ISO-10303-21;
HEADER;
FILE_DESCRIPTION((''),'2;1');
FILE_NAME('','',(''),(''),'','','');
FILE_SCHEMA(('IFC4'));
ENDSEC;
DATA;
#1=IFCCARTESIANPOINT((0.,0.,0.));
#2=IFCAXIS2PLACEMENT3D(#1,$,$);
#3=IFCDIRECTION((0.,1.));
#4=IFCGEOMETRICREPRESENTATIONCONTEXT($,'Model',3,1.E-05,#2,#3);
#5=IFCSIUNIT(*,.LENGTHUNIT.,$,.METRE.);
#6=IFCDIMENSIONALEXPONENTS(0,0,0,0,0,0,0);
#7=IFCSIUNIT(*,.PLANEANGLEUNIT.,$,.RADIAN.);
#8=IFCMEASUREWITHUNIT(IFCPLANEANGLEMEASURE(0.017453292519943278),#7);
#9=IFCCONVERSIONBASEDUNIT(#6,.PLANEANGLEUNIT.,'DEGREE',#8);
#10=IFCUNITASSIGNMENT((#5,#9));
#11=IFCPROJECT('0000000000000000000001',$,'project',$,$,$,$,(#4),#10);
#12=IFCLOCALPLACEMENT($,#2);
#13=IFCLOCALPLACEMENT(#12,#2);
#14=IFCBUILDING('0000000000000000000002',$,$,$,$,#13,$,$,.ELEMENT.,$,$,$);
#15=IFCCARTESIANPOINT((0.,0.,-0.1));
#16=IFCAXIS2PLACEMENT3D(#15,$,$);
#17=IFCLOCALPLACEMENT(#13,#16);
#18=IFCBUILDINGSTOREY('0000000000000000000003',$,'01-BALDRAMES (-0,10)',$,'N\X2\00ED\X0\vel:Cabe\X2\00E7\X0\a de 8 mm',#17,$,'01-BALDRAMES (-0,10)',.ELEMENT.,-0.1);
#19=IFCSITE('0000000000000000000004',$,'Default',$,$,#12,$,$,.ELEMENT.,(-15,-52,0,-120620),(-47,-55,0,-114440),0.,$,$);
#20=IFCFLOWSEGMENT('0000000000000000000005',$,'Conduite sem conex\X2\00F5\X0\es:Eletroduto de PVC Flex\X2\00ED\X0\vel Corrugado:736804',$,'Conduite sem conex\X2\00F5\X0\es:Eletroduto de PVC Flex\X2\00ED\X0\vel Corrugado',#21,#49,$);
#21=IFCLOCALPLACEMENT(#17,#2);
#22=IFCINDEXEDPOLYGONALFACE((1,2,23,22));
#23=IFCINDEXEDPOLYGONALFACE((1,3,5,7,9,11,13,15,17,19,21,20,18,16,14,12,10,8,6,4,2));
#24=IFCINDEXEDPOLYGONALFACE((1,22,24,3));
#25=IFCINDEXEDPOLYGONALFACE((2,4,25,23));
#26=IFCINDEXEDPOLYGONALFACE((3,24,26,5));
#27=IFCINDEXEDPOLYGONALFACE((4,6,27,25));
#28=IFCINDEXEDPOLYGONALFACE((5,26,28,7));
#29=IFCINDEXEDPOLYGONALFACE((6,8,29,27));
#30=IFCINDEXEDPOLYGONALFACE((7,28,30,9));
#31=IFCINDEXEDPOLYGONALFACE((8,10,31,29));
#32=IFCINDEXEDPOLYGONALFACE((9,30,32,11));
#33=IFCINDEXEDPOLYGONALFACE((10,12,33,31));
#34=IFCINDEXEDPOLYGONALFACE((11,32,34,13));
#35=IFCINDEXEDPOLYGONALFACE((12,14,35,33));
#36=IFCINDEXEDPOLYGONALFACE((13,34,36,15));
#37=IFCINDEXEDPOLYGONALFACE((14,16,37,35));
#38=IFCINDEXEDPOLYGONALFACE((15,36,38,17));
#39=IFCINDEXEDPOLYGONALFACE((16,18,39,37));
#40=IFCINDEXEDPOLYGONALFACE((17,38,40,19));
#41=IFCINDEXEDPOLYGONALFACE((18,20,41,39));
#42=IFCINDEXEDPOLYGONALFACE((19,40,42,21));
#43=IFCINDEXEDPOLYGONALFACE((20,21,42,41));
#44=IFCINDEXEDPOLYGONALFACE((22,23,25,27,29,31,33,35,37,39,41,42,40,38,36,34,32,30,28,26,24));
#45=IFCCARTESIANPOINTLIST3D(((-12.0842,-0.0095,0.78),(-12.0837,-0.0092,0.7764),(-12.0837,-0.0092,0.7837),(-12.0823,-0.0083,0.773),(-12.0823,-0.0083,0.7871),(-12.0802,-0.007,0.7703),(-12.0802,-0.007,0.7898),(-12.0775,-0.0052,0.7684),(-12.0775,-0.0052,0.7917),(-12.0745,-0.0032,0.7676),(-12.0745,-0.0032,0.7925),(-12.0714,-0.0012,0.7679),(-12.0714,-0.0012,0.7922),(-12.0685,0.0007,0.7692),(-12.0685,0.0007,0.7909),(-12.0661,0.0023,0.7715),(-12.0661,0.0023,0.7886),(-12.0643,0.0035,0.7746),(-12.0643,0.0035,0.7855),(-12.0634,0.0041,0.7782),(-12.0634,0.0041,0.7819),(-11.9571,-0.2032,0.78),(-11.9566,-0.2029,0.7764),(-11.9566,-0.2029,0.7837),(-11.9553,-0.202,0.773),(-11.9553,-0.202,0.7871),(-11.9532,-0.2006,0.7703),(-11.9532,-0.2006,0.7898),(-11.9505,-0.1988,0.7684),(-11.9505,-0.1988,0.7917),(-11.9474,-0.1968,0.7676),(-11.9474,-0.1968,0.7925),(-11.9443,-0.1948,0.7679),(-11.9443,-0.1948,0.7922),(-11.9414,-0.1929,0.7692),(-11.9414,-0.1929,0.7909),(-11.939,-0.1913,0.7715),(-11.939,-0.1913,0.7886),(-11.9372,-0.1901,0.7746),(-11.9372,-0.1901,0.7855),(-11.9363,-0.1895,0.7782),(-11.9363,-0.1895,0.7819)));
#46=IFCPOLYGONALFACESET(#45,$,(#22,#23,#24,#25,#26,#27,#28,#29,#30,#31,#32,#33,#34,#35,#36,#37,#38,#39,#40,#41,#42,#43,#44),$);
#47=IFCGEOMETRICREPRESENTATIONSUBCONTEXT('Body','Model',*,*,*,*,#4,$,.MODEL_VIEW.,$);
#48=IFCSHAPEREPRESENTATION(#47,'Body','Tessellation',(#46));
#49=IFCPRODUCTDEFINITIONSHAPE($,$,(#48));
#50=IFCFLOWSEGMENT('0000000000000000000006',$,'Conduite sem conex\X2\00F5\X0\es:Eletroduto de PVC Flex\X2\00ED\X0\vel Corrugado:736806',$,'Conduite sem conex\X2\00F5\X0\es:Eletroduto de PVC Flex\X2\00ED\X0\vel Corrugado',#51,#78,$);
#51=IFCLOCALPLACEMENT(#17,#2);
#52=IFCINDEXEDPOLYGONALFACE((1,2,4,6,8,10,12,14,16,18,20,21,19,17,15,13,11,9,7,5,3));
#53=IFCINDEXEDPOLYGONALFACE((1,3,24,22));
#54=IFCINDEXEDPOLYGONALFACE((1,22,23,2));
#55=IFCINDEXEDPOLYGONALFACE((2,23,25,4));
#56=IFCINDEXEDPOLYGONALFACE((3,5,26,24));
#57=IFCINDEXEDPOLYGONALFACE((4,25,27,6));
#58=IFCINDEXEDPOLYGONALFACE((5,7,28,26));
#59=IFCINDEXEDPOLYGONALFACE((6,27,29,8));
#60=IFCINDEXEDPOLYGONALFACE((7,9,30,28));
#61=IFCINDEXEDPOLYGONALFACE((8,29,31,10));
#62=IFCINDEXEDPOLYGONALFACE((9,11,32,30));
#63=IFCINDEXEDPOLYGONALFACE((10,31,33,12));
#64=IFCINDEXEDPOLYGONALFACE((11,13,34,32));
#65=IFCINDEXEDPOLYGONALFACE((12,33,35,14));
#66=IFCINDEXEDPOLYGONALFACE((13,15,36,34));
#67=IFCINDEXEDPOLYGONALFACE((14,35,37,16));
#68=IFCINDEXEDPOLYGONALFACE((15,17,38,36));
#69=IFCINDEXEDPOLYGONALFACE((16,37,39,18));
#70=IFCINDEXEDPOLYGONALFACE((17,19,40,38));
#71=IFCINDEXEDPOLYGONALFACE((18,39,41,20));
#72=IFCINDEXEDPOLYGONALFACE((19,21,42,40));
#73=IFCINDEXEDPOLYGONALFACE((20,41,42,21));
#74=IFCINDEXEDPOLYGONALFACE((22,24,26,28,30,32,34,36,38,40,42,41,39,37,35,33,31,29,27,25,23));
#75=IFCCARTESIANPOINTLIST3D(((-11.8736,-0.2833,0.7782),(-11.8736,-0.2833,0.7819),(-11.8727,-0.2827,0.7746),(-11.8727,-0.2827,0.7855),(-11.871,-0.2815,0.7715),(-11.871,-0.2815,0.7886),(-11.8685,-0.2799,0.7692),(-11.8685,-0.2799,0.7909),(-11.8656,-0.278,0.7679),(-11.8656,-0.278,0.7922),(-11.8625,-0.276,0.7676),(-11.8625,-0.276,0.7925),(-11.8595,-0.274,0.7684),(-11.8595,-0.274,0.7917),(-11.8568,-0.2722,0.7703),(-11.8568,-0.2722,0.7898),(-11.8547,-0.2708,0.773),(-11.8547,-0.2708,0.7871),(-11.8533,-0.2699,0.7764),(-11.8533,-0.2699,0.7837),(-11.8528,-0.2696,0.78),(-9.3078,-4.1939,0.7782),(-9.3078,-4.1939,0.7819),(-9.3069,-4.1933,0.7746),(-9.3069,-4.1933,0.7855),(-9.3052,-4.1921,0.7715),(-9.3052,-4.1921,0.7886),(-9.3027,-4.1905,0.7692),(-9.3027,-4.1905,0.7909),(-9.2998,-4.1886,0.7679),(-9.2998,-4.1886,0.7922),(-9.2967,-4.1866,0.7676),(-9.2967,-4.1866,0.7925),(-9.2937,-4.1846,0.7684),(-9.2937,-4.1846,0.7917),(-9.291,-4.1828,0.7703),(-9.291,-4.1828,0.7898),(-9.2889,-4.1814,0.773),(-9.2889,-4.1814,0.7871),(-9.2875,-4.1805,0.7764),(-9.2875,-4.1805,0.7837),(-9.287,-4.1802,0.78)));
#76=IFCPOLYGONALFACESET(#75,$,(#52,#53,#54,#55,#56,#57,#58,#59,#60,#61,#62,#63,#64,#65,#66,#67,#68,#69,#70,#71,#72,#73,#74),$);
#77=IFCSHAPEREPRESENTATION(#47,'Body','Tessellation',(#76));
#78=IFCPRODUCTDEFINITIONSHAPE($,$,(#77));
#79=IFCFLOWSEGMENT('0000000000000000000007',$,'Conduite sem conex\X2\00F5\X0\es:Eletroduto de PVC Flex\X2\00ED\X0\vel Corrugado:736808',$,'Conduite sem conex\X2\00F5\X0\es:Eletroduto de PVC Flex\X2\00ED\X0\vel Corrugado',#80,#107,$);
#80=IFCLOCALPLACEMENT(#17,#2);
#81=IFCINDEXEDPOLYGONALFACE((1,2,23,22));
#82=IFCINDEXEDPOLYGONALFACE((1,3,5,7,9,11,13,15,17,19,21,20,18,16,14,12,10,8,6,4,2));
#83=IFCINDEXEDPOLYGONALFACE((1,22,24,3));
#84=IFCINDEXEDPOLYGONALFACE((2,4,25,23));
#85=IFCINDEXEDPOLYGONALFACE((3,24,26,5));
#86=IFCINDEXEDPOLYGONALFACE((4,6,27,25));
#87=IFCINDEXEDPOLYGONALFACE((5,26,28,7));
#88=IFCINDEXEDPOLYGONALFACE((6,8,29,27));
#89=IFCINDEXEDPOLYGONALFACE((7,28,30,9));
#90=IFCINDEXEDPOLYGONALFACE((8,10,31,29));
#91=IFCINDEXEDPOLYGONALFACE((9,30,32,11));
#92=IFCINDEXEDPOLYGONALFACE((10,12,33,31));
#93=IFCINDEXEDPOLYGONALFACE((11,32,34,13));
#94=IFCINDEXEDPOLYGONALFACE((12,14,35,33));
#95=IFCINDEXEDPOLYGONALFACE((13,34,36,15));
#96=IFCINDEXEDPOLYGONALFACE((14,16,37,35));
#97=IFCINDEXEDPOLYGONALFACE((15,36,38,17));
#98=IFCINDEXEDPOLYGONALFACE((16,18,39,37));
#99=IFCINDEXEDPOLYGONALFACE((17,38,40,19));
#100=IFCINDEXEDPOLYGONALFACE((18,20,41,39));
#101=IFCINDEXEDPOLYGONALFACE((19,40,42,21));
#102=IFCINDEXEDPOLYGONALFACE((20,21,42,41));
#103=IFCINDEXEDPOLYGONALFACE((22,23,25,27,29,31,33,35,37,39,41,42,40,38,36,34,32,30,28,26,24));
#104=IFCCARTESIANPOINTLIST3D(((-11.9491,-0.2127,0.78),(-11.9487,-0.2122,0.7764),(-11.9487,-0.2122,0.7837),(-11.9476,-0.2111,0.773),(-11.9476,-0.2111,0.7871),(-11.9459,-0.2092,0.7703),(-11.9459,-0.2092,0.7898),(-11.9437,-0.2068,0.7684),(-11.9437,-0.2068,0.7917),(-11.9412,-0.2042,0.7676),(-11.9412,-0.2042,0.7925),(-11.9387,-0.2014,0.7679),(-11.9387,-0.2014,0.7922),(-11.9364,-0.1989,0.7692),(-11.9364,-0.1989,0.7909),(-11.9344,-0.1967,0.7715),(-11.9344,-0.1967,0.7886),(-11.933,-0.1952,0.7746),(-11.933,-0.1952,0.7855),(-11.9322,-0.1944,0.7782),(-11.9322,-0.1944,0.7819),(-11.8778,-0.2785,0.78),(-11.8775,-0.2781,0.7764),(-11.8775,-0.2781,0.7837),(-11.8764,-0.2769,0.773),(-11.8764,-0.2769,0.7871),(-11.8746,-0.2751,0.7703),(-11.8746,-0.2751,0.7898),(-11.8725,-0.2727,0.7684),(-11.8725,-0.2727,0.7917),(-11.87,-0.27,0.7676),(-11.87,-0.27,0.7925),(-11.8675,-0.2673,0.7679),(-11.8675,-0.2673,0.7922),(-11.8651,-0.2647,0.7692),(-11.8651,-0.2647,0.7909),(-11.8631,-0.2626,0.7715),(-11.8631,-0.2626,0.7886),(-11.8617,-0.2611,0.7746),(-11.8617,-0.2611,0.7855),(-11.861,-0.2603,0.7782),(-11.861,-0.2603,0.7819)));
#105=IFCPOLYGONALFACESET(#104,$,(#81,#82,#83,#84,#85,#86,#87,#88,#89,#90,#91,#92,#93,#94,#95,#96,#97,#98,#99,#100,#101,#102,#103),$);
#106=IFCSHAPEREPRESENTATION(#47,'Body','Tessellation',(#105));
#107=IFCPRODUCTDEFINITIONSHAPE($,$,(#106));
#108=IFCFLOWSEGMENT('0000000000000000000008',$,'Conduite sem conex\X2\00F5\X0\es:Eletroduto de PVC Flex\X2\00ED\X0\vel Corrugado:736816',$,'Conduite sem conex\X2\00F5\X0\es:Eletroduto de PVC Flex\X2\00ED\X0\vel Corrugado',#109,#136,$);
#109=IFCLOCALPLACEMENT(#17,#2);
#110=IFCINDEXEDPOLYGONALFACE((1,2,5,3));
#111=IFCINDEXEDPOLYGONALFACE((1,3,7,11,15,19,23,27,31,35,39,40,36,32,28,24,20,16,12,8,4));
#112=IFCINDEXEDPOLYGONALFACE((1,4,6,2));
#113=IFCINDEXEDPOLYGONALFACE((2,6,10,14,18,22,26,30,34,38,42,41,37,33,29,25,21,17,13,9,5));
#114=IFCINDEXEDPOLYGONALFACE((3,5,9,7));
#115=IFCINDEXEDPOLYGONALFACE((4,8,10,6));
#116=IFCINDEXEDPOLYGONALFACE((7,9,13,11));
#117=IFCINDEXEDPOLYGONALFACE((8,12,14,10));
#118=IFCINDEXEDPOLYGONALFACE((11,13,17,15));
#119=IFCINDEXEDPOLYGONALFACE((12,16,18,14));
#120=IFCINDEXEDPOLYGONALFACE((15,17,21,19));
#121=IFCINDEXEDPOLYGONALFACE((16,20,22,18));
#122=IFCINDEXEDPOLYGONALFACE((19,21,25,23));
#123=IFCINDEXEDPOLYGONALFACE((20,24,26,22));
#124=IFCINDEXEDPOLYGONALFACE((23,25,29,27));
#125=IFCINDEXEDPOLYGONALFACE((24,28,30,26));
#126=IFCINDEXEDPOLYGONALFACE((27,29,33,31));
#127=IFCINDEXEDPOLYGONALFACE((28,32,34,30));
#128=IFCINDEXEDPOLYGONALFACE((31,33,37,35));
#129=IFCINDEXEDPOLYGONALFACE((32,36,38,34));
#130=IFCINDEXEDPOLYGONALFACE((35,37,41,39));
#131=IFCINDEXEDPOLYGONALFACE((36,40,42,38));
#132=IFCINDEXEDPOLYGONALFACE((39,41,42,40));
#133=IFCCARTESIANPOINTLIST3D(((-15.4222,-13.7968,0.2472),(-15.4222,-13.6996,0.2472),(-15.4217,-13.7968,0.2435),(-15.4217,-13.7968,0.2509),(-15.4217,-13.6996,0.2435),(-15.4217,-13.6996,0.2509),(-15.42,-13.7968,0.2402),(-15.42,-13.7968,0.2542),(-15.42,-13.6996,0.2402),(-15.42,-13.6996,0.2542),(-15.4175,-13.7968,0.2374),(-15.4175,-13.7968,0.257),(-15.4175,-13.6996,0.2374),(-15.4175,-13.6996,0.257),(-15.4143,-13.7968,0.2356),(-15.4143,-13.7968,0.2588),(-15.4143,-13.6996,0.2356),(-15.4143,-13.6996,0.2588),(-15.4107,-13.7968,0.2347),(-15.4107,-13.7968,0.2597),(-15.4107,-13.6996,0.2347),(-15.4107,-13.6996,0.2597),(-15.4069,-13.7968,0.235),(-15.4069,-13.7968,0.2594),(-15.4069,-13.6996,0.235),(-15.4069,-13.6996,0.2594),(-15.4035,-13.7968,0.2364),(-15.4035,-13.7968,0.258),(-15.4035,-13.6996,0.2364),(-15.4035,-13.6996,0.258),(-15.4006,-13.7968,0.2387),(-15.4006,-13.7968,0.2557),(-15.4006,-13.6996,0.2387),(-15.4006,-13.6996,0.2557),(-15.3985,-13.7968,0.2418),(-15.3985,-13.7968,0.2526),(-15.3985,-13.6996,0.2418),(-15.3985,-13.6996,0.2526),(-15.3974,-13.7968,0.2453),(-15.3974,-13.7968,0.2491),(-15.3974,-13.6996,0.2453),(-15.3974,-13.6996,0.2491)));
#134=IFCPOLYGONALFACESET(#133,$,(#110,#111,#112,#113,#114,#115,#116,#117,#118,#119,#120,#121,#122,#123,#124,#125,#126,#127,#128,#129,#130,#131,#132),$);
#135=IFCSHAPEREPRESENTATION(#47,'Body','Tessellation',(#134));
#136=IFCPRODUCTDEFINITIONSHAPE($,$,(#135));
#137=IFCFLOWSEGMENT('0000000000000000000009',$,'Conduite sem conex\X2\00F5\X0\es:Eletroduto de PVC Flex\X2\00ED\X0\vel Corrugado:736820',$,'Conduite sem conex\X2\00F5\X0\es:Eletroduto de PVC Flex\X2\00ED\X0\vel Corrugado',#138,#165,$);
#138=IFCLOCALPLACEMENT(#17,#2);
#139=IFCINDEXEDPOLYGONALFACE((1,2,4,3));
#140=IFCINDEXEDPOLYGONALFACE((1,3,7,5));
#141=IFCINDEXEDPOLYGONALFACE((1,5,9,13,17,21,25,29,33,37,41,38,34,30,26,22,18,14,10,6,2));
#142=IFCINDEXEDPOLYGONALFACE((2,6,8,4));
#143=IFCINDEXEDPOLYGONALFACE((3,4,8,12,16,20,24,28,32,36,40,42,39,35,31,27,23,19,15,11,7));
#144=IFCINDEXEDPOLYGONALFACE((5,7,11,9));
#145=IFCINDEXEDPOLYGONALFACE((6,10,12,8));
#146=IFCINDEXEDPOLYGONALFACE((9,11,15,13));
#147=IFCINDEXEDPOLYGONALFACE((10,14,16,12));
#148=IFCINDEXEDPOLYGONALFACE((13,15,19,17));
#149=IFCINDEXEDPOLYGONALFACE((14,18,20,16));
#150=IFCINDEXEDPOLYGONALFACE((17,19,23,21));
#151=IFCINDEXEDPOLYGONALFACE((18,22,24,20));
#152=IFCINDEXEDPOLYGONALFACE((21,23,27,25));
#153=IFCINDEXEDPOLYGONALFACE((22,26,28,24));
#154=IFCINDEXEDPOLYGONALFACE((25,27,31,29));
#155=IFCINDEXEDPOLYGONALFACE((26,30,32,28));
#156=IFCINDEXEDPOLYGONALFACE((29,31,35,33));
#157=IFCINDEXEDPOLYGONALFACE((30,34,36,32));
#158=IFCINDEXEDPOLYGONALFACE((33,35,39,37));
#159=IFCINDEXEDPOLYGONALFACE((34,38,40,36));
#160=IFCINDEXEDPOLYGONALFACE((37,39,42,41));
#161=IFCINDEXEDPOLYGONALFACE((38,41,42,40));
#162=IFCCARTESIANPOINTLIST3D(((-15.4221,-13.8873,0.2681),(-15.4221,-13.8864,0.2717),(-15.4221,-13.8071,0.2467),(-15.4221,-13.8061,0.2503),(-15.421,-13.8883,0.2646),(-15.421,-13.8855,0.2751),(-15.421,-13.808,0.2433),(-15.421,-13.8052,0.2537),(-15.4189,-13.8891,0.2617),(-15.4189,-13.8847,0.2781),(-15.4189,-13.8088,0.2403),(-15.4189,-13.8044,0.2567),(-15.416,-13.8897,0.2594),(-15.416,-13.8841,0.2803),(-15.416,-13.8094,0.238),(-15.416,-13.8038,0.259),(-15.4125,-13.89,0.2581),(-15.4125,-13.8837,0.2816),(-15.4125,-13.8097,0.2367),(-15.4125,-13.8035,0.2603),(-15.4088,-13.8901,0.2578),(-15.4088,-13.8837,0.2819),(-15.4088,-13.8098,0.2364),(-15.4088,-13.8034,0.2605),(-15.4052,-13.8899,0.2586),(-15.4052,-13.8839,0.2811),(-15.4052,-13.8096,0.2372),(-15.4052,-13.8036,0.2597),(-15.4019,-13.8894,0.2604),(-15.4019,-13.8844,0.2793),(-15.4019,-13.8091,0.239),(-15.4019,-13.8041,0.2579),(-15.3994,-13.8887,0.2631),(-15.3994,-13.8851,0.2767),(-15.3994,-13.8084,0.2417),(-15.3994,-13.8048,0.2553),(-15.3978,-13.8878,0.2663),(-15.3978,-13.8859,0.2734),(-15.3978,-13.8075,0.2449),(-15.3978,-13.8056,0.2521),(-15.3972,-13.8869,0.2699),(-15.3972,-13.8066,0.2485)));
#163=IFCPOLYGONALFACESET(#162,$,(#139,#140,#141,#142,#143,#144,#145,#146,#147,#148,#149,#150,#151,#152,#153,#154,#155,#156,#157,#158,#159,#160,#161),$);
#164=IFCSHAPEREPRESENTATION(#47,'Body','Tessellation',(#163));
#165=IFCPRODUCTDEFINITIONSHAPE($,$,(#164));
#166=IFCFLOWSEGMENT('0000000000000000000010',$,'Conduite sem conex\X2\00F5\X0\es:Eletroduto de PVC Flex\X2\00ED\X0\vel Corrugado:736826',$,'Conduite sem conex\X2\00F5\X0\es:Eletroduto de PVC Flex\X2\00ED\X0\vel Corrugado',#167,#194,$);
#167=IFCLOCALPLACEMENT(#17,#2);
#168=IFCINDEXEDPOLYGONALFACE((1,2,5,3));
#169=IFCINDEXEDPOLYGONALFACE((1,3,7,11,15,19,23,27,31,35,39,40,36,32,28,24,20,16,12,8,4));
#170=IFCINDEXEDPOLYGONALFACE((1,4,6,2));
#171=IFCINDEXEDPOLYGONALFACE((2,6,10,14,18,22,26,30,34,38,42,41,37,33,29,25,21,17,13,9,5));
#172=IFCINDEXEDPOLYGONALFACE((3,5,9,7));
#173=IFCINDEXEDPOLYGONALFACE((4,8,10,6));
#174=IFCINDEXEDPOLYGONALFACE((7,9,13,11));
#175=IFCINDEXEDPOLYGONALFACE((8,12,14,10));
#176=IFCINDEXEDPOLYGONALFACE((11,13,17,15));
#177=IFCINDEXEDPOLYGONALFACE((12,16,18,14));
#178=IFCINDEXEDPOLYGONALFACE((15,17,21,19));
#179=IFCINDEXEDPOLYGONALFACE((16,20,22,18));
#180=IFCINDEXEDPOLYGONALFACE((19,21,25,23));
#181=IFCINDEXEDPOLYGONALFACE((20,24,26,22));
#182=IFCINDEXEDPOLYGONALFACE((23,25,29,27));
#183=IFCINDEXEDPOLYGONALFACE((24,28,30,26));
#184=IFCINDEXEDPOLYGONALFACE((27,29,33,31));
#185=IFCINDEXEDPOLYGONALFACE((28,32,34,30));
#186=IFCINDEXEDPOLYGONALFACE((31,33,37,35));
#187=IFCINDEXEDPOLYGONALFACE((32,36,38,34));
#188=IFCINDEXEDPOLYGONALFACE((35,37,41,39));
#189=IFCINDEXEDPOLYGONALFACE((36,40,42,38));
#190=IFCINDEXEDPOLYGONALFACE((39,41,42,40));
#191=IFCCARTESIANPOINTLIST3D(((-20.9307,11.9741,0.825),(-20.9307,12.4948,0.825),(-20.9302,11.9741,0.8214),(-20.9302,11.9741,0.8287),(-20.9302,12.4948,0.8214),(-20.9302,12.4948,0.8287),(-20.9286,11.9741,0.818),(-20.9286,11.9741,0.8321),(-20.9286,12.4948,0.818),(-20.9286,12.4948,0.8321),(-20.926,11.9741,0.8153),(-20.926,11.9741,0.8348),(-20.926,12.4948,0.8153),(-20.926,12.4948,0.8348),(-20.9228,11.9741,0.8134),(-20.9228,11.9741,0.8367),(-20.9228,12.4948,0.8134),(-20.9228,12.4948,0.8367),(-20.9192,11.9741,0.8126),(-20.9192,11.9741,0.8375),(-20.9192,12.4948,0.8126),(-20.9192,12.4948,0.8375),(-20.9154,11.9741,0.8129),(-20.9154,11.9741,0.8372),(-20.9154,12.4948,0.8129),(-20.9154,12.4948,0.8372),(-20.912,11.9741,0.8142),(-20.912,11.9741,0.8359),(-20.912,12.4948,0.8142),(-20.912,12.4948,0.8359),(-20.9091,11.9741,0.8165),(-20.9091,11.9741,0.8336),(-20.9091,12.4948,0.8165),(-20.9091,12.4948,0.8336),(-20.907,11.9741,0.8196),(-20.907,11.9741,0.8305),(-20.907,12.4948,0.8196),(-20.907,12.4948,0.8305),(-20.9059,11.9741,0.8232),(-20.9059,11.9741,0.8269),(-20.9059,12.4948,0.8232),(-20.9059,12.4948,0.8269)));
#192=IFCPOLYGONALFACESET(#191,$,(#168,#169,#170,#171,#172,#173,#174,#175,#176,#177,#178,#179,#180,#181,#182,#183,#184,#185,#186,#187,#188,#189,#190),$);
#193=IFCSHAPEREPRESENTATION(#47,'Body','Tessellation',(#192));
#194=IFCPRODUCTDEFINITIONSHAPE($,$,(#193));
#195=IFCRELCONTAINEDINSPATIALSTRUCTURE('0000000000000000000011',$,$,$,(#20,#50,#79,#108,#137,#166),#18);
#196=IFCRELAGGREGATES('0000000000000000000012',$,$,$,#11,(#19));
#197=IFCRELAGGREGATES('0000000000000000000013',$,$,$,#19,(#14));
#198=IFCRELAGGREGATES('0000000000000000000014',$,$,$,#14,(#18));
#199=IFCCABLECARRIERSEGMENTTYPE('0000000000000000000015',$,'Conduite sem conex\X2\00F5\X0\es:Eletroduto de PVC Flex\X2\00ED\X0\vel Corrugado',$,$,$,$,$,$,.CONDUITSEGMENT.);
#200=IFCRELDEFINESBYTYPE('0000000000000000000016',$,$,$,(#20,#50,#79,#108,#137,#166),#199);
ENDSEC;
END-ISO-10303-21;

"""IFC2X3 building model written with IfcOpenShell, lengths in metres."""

from ifc_helpers import new_model, entity, si_unit, converted_unit, direction, frame, frame_2d, origin, origin_2d_with_axis, place, context, subcontext, project, spatial, circle, extrude, type_object, element, save


model = new_model("IFC2X3")

# Units and contexts
model_context = context("Model", 3, precision=1e-05, world=origin(), true_north=direction((0.0, 1.0)))
body_context = subcontext(model_context, "Body", "Model", "MODEL_VIEW")
ifc_project = project(units=[si_unit("LENGTHUNIT", "METRE"), converted_unit("PLANEANGLEUNIT", "DEGREE", entity("IfcPlaneAngleMeasure", 0.017453292519943278), si_unit("PLANEANGLEUNIT", "RADIAN"), dimensions=[0, 0, 0, 0, 0, 0, 0])], contexts=[model_context])

# Site, building, storey
site_placement = place(None, origin())
site = spatial("IfcSite", under=ifc_project, at=site_placement, Name="Default", CompositionType="ELEMENT", RefLatitude=(-15, -52, 0, -120620), RefLongitude=(-47, -55, 0, -114440), RefElevation=0.0)
building_placement = place(site_placement, origin())
building = spatial("IfcBuilding", under=site, at=building_placement, CompositionType="ELEMENT")
storey_placement = place(building_placement, frame((0.0, 0.0, -0.1)))
storey = spatial("IfcBuildingStorey", under=building, at=storey_placement, Name="01-BALDRAMES (-0,10)", ObjectType="Nível:Cabeça de 8 mm", LongName="01-BALDRAMES (-0,10)", CompositionType="ELEMENT", Elevation=-0.1)

# Flow segments
cable_carrier_segment_type = type_object("IfcCableCarrierSegmentType", Name="Conduite sem conexões:Eletroduto de PVC Flexível Corrugado", PredefinedType="CONDUITSEGMENT")
flow_segment_1_placement = place(storey_placement, origin())
element("IfcFlowSegment", 1, at=flow_segment_1_placement, inside=storey, type_object=cable_carrier_segment_type, Name="Conduite sem conexões:Eletroduto de PVC Flexível Corrugado:736804", ObjectType="Conduite sem conexões:Eletroduto de PVC Flexível Corrugado", context=body_context, shape_type="SweptSolid", body=[
    extrude(circle(Radius=0.0125, at=frame_2d((0.0, 0.0), x_axis=(1.0, 0.0))), frame((-11.9467, -0.1963, 0.78), z_axis=(-0.548576, 0.836101, 0.0), x_axis=(-0.836101, -0.548576, 0.0)), (0.0, 0.0, 1.0), 0.2316),
])
flow_segment_2_placement = place(storey_placement, origin())
element("IfcFlowSegment", 2, at=flow_segment_2_placement, inside=storey, type_object=cable_carrier_segment_type, Name="Conduite sem conexões:Eletroduto de PVC Flexível Corrugado:736806", ObjectType="Conduite sem conexões:Eletroduto de PVC Flexível Corrugado", context=body_context, shape_type="SweptSolid", body=[
    extrude(circle(Radius=0.0125, at=frame_2d((0.0, 0.0), x_axis=(1.0, 0.0))), frame((-11.8633, -0.2765, 0.78), z_axis=(0.548576, -0.836101, 0.0), x_axis=(0.836101, 0.548576, 0.0)), (0.0, 0.0, 1.0), 4.6772),
])
flow_segment_3_placement = place(storey_placement, origin())
element("IfcFlowSegment", 3, at=flow_segment_3_placement, inside=storey, type_object=cable_carrier_segment_type, Name="Conduite sem conexões:Eletroduto de PVC Flexível Corrugado:736808", ObjectType="Conduite sem conexões:Eletroduto de PVC Flexível Corrugado", context=body_context, shape_type="SweptSolid", body=[
    extrude(circle(Radius=0.0125, at=origin_2d_with_axis()), frame((-11.8694, -0.2693, 0.78), z_axis=(-0.734349, 0.678772, 0.0), x_axis=(-0.678772, -0.734349, 0.0)), (0.0, 0.0, 1.0), 0.097),
])
flow_segment_4_placement = place(storey_placement, origin())
element("IfcFlowSegment", 4, at=flow_segment_4_placement, inside=storey, type_object=cable_carrier_segment_type, Name="Conduite sem conexões:Eletroduto de PVC Flexível Corrugado:736816", ObjectType="Conduite sem conexões:Eletroduto de PVC Flexível Corrugado", context=body_context, shape_type="SweptSolid", body=[
    extrude(circle(Radius=0.0125, at=frame_2d((0.0, 0.0), x_axis=(1.0, 0.0))), frame((-15.4097, -13.7968, 0.2472), z_axis=(0.0, 1.0, 0.0), x_axis=(-1.0, 0.0, 0.0)), (0.0, 0.0, 1.0), 0.0972),
])
flow_segment_5_placement = place(storey_placement, origin())
element("IfcFlowSegment", 5, at=flow_segment_5_placement, inside=storey, type_object=cable_carrier_segment_type, Name="Conduite sem conexões:Eletroduto de PVC Flexível Corrugado:736820", ObjectType="Conduite sem conexões:Eletroduto de PVC Flexível Corrugado", context=body_context, shape_type="SweptSolid", body=[
    extrude(circle(Radius=0.0125, at=frame_2d((0.0, 0.0), x_axis=(1.0, 0.0))), frame((-15.4097, -13.8869, 0.2699), z_axis=(0.0, 0.966328, -0.257315), x_axis=(1.0, 0.0, 0.0)), (0.0, 0.0, 1.0), 0.0831),
])
flow_segment_6_placement = place(storey_placement, origin())
element("IfcFlowSegment", 6, at=flow_segment_6_placement, inside=storey, type_object=cable_carrier_segment_type, Name="Conduite sem conexões:Eletroduto de PVC Flexível Corrugado:736826", ObjectType="Conduite sem conexões:Eletroduto de PVC Flexível Corrugado", context=body_context, shape_type="SweptSolid", body=[
    extrude(circle(Radius=0.0125, at=origin_2d_with_axis()), frame((-20.9182, 11.9741, 0.825), z_axis=(0.0, 1.0, 0.0), x_axis=(-1.0, 0.0, 0.0)), (0.0, 0.0, 1.0), 0.5207),
])

save(model, "model.ifc")
